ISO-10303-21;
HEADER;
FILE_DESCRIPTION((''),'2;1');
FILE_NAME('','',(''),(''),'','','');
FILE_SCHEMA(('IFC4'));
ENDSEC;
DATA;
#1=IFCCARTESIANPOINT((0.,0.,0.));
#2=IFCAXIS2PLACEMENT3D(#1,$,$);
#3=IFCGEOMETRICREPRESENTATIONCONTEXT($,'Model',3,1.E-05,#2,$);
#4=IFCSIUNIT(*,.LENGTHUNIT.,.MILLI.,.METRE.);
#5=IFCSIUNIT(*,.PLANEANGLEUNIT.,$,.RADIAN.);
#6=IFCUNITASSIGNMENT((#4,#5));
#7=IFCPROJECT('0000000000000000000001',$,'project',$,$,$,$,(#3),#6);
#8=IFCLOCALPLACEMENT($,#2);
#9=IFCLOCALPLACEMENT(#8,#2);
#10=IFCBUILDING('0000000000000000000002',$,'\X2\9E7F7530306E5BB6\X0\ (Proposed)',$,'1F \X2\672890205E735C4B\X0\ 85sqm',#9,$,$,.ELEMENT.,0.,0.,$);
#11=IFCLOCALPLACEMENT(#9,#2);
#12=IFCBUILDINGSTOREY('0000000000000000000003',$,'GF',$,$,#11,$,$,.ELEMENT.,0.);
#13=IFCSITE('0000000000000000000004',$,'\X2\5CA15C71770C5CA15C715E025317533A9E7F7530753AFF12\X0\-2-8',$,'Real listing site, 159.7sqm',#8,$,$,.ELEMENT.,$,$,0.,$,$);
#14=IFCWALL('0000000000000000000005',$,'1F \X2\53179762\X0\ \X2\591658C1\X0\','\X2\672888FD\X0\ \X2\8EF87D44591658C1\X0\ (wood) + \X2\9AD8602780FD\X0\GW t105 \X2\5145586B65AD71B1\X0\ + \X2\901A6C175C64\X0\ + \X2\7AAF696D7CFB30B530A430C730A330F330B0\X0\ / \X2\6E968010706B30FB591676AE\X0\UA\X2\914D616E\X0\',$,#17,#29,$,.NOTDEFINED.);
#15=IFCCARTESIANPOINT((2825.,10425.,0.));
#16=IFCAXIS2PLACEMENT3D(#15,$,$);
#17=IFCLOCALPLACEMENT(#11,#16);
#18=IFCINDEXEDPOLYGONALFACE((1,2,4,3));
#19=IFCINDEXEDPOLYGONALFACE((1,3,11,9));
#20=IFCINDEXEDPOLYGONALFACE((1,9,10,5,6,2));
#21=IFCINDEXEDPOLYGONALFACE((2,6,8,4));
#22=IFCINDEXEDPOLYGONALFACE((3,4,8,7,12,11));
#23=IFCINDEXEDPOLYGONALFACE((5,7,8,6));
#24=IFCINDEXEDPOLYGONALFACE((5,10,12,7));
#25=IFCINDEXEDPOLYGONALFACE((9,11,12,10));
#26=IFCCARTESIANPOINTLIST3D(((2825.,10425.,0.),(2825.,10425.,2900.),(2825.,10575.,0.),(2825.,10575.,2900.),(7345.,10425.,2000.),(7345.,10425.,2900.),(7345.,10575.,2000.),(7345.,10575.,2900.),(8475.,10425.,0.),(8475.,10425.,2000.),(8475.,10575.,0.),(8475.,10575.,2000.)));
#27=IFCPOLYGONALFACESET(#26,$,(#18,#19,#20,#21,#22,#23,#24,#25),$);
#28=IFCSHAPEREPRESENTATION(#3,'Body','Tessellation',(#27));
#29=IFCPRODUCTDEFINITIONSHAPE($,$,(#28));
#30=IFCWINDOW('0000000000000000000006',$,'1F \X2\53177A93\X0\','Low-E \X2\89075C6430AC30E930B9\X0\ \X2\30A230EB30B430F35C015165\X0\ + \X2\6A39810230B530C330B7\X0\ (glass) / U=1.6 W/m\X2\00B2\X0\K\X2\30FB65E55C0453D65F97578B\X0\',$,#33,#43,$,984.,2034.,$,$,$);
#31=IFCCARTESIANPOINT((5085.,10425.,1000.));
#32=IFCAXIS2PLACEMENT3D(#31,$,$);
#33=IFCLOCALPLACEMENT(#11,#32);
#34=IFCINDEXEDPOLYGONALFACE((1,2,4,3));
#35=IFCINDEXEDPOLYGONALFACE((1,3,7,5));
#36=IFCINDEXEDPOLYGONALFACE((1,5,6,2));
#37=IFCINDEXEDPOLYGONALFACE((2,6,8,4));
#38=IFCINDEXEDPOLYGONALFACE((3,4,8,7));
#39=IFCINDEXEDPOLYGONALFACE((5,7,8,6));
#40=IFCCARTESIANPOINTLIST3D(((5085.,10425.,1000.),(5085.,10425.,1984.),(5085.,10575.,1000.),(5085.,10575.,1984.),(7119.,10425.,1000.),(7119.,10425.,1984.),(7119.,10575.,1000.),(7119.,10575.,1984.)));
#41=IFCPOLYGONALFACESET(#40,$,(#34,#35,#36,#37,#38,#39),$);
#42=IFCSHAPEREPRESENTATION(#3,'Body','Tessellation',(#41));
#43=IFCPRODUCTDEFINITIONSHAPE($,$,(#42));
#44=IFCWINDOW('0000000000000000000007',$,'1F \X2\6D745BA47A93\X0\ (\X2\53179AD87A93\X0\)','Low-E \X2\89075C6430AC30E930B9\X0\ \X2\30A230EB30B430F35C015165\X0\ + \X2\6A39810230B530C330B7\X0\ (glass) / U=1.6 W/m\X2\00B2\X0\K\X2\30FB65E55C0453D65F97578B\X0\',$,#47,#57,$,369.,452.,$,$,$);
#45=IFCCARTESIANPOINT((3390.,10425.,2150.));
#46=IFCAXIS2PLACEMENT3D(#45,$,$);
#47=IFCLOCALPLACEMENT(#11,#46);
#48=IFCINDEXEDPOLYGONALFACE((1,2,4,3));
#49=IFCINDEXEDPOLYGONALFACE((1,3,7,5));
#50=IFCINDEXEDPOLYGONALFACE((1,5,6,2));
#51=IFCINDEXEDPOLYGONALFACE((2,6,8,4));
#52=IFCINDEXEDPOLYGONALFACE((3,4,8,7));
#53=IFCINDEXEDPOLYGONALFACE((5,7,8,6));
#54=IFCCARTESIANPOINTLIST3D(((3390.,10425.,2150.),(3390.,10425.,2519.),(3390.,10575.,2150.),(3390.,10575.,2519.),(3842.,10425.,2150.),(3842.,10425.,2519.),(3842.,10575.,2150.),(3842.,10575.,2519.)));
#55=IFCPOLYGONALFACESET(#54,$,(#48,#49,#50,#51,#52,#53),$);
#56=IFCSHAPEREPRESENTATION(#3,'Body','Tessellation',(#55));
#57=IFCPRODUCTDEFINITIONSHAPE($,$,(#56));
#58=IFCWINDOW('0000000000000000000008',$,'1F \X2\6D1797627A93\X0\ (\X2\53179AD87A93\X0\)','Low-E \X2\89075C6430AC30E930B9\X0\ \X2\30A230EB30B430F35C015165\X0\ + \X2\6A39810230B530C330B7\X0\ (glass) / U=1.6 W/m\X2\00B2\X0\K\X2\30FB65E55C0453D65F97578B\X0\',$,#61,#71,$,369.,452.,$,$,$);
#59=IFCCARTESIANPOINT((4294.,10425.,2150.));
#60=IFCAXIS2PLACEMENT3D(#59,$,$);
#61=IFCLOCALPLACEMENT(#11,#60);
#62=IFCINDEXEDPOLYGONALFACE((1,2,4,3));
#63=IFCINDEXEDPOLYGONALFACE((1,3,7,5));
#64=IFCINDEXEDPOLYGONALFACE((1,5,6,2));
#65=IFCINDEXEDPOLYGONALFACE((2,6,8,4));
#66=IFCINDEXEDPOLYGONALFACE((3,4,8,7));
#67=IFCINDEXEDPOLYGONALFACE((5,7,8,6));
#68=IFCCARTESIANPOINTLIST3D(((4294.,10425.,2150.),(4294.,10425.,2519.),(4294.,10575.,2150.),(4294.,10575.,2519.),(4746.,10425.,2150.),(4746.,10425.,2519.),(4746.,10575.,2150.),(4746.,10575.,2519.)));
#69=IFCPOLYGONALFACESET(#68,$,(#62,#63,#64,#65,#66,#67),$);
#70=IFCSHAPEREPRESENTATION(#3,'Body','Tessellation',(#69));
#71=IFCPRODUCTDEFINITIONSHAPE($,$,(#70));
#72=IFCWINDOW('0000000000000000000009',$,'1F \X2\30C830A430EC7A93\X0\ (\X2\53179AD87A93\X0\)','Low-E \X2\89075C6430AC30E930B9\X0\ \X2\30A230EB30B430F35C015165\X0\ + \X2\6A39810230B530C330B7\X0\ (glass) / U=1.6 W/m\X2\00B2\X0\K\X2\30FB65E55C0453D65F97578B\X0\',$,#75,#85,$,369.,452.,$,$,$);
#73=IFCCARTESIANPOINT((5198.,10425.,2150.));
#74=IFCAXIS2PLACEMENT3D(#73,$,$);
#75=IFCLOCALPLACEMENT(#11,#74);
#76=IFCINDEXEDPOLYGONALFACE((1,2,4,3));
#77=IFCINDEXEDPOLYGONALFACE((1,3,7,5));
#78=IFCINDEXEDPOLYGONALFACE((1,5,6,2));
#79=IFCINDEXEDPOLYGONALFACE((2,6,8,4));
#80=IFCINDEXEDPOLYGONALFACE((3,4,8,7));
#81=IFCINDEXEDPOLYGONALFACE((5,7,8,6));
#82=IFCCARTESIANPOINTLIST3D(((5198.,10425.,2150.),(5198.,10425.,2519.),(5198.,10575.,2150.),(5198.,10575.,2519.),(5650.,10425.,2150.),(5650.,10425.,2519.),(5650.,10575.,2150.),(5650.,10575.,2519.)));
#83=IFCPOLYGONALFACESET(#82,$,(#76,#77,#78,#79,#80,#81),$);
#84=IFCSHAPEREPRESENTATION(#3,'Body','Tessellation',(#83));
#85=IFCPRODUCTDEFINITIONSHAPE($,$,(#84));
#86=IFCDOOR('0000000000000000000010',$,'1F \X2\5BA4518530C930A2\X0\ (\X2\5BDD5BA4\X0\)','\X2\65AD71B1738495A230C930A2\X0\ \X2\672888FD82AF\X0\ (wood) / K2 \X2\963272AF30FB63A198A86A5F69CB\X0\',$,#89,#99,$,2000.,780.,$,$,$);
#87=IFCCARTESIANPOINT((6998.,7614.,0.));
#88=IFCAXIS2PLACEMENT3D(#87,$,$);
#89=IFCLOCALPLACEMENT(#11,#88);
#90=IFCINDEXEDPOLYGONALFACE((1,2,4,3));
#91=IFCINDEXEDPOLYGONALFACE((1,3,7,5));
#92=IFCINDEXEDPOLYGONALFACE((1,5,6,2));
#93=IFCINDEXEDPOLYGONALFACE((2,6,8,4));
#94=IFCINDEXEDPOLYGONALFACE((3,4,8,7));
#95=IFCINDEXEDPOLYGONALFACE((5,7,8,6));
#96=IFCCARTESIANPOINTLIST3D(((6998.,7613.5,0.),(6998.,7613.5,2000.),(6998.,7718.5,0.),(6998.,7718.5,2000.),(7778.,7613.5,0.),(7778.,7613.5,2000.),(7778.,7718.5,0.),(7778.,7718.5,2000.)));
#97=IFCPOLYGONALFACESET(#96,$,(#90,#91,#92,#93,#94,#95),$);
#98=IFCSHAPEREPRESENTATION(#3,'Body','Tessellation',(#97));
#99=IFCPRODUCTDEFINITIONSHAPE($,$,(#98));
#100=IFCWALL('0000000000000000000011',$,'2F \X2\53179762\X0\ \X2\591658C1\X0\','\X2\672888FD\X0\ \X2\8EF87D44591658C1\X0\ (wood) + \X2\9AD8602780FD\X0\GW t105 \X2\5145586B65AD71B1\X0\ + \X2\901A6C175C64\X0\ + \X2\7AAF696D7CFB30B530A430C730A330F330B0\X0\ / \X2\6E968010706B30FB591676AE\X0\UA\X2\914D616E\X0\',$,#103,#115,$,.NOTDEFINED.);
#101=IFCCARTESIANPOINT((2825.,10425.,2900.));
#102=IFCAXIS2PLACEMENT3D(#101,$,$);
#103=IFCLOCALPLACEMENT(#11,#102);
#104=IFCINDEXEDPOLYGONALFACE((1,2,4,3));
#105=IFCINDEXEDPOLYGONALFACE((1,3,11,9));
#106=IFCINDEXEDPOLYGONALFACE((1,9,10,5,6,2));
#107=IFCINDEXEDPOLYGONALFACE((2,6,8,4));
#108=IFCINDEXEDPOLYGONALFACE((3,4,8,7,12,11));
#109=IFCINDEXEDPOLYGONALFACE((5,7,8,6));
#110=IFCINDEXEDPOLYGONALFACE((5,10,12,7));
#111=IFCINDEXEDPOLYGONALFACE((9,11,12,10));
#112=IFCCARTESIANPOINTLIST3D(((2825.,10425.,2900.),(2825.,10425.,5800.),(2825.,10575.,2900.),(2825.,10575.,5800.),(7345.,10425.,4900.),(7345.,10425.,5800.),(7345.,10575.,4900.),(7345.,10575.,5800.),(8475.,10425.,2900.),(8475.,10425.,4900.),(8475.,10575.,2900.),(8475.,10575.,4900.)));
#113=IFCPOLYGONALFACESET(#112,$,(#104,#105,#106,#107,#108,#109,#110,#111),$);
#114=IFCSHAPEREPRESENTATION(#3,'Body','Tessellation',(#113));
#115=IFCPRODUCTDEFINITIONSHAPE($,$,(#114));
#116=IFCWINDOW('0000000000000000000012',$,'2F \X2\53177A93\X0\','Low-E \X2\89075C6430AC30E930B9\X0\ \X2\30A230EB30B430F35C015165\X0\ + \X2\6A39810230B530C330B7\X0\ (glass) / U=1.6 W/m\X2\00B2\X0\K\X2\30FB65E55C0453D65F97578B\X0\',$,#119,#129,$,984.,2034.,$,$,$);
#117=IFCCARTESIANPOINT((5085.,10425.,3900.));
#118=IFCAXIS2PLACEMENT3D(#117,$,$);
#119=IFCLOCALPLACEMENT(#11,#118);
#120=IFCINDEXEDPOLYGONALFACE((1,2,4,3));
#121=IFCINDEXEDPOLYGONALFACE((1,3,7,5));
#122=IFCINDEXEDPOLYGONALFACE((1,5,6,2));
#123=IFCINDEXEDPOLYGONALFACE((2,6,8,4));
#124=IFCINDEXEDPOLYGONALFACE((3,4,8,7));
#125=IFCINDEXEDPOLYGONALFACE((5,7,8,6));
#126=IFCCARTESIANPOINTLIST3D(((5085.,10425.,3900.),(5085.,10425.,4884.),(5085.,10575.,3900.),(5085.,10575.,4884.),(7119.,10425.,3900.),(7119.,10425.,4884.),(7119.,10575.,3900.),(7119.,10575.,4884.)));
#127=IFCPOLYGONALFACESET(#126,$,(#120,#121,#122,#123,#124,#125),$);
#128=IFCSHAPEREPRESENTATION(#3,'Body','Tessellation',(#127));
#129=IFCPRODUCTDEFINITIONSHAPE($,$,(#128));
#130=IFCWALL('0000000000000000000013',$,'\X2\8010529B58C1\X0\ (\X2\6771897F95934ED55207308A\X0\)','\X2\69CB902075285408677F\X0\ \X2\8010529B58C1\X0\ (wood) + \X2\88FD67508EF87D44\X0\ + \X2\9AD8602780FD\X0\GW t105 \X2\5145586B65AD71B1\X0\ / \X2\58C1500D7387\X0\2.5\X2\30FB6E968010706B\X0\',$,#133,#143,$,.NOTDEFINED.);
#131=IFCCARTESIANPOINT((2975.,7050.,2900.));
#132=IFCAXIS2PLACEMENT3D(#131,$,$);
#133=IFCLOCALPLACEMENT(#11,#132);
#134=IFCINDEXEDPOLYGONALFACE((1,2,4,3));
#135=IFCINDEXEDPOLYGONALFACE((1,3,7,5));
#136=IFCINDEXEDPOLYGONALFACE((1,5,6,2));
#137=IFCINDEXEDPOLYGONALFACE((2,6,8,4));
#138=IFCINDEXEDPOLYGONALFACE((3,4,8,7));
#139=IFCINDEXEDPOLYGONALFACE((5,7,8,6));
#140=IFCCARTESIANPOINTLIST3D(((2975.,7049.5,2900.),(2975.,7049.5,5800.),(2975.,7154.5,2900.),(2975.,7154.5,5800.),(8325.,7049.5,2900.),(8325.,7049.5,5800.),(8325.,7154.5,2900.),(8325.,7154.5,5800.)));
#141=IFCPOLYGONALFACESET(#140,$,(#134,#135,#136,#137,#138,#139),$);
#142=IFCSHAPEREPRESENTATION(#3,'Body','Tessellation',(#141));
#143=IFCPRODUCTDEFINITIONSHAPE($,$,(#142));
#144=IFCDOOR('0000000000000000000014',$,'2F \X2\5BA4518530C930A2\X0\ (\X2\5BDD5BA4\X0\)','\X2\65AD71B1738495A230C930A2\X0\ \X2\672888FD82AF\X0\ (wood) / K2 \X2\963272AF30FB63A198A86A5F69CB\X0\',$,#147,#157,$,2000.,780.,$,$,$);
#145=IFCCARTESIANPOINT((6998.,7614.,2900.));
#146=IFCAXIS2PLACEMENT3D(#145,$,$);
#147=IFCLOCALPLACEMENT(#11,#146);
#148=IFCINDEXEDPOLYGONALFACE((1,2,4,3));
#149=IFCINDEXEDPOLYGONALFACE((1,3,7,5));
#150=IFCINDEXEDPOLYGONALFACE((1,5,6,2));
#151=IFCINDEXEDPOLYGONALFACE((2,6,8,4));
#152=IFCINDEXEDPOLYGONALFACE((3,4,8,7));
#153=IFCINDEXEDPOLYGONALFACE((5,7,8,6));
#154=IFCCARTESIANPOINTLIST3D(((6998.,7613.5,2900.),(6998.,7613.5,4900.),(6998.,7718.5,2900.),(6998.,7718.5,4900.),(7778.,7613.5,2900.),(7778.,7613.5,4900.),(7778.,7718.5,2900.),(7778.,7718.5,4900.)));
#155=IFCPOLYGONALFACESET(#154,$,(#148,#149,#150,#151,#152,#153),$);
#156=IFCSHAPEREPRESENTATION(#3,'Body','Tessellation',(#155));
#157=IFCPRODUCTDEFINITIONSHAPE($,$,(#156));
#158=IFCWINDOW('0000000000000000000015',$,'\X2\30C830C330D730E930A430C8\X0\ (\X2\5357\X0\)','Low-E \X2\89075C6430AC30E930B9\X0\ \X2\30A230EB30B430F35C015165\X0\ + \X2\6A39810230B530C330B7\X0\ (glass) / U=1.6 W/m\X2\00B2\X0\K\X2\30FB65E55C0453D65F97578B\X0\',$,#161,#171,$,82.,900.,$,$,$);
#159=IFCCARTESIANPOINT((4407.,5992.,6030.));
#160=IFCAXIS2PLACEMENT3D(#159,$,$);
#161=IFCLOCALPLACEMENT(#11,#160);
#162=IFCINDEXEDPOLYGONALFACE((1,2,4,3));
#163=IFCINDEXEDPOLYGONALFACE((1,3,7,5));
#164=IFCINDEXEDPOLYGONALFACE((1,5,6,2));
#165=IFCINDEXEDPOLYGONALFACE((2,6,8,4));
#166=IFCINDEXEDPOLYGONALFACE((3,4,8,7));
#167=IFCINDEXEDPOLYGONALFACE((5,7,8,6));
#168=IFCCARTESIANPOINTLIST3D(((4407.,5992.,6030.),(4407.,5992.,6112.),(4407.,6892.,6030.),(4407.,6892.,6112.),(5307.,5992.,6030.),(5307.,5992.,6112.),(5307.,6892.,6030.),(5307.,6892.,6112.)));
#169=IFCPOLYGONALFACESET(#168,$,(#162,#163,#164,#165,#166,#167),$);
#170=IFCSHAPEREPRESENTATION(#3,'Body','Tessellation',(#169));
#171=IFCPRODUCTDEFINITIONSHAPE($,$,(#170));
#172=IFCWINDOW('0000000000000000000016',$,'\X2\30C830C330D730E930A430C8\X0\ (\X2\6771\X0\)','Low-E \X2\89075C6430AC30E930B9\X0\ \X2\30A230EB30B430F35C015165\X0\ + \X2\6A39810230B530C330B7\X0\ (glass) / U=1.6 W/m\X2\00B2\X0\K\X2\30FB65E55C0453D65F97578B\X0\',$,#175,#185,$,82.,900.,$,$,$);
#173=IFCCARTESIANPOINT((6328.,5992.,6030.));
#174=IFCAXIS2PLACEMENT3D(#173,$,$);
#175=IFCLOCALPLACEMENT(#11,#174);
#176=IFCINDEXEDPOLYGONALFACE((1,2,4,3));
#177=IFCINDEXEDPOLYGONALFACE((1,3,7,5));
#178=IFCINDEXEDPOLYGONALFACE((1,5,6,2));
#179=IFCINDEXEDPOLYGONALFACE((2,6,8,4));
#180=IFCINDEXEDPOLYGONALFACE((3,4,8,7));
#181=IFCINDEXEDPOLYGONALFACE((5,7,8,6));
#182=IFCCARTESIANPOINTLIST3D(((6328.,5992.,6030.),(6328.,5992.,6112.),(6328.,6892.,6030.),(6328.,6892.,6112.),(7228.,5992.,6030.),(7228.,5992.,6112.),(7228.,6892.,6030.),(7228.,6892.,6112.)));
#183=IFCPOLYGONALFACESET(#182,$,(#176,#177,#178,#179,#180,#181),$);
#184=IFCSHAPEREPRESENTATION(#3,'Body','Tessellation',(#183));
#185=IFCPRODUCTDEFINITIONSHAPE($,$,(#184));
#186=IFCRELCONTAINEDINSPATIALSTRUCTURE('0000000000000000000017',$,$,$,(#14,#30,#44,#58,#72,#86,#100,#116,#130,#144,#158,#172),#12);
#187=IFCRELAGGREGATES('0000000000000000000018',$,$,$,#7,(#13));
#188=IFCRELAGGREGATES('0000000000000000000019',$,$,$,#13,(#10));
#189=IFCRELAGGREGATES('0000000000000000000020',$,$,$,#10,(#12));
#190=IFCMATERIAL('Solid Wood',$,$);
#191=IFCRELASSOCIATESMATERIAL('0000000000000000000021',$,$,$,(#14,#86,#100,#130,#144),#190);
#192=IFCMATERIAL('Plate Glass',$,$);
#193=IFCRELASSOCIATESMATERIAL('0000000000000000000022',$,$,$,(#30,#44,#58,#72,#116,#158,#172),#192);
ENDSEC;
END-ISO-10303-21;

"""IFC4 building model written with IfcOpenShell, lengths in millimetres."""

from ifc_helpers import new_model, si_unit, frame, frame_2d, origin, place, context, project, spatial, rectangle, extrude, material, element, fill, save


model = new_model("IFC4")

# Units and contexts
model_context = context("Model", 3, precision=1e-05, world=origin())
ifc_project = project(units=[si_unit("LENGTHUNIT", "METRE", prefix="MILLI"), si_unit("PLANEANGLEUNIT", "RADIAN")], contexts=[model_context])

# Site, building, storey
site_placement = place(None, origin())
site = spatial("IfcSite", under=ifc_project, at=site_placement, Name="岡山県岡山市北区鹿田町２-2-8", ObjectType="Real listing site, 159.7sqm", CompositionType="ELEMENT", RefElevation=0.0)
building_placement = place(site_placement, origin())
building = spatial("IfcBuilding", under=site, at=building_placement, Name="鹿田の家 (Proposed)", ObjectType="1F 木造平屋 85sqm", CompositionType="ELEMENT", ElevationOfRefHeight=0.0, ElevationOfTerrain=0.0)
storey_placement = place(building_placement, origin())
storey = spatial("IfcBuildingStorey", under=building, at=storey_placement, Name="GF", CompositionType="ELEMENT", Elevation=0.0)

# Wall, openings, windows
ifc_material_1 = material(Name="Solid Wood")
wall_1_placement = place(storey_placement, frame((2825.0, 10425.0, 0.0)))
wall_1 = element("IfcWall", 1, at=wall_1_placement, inside=storey, material=ifc_material_1, Name="1F 北面 外壁", Description="木製 軸組外壁 (wood) + 高性能GW t105 充填断熱 + 通気層 + 窯業系サイディング / 準耐火・外皮UA配慮", PredefinedType="NOTDEFINED", context=model_context, shape_type="SweptSolid", body=[
    extrude(rectangle(XDim=5650.0, YDim=150.0, at=frame_2d((2825.0, 75.0))), frame((2825.0, 10425.0, 0.0)), (0.0, 0.0, 1.0), 2900.0),
])
opening_1_placement = place(storey_placement, frame((5085.0, 10425.0, 1000.0)))
opening_1 = element("IfcOpeningElement", 2, at=opening_1_placement, cuts=wall_1, PredefinedType="NOTDEFINED", context=model_context, shape_type="SweptSolid", body=[
    extrude(rectangle(XDim=2034.0, YDim=150.0, at=frame_2d((1017.0, 75.0))), frame((5085.0, 10425.0, 1000.0)), (0.0, 0.0, 1.0), 984.0),
])
opening_2_placement = place(storey_placement, frame((3390.0, 10425.0, 2150.0)))
opening_2 = element("IfcOpeningElement", 3, at=opening_2_placement, cuts=wall_1, PredefinedType="NOTDEFINED", context=model_context, shape_type="SweptSolid", body=[
    extrude(rectangle(XDim=452.0, YDim=150.0, at=frame_2d((226.0, 75.0))), frame((3390.0, 10425.0, 2150.0)), (0.0, 0.0, 1.0), 369.0),
])
opening_3_placement = place(storey_placement, frame((4294.0, 10425.0, 2150.0)))
opening_3 = element("IfcOpeningElement", 4, at=opening_3_placement, cuts=wall_1, PredefinedType="NOTDEFINED", context=model_context, shape_type="SweptSolid", body=[
    extrude(rectangle(XDim=452.0, YDim=150.0, at=frame_2d((226.0, 75.0))), frame((4294.0, 10425.0, 2150.0)), (0.0, 0.0, 1.0), 369.0),
])
opening_4_placement = place(storey_placement, frame((5198.0, 10425.0, 2150.0)))
opening_4 = element("IfcOpeningElement", 5, at=opening_4_placement, cuts=wall_1, PredefinedType="NOTDEFINED", context=model_context, shape_type="SweptSolid", body=[
    extrude(rectangle(XDim=452.0, YDim=150.0, at=frame_2d((226.0, 75.0))), frame((5198.0, 10425.0, 2150.0)), (0.0, 0.0, 1.0), 369.0),
])
ifc_material_2 = material(Name="Plate Glass")
window_1_placement = place(storey_placement, frame((5085.0, 10425.0, 1000.0)))
window_1 = element("IfcWindow", 6, at=window_1_placement, inside=storey, material=ifc_material_2, Name="1F 北窓", Description="Low-E 複層ガラス アルゴン封入 + 樹脂サッシ (glass) / U=1.6 W/m²K・日射取得型", OverallHeight=984.0, OverallWidth=2034.0, context=model_context, shape_type="SweptSolid", body=[
    extrude(rectangle(XDim=2034.0, YDim=150.0, at=frame_2d((1017.0, 75.0))), frame((5085.0, 10425.0, 1000.0)), (0.0, 0.0, 1.0), 984.0),
])
fill(opening_1, window_1)
window_2_placement = place(storey_placement, frame((3390.0, 10425.0, 2150.0)))
window_2 = element("IfcWindow", 7, at=window_2_placement, inside=storey, material=ifc_material_2, Name="1F 浴室窓 (北高窓)", Description="Low-E 複層ガラス アルゴン封入 + 樹脂サッシ (glass) / U=1.6 W/m²K・日射取得型", OverallHeight=369.0, OverallWidth=452.0, context=model_context, shape_type="SweptSolid", body=[
    extrude(rectangle(XDim=452.0, YDim=150.0, at=frame_2d((226.0, 75.0))), frame((3390.0, 10425.0, 2150.0)), (0.0, 0.0, 1.0), 369.0),
])
fill(opening_2, window_2)
window_3_placement = place(storey_placement, frame((4294.0, 10425.0, 2150.0)))
window_3 = element("IfcWindow", 8, at=window_3_placement, inside=storey, material=ifc_material_2, Name="1F 洗面窓 (北高窓)", Description="Low-E 複層ガラス アルゴン封入 + 樹脂サッシ (glass) / U=1.6 W/m²K・日射取得型", OverallHeight=369.0, OverallWidth=452.0, context=model_context, shape_type="SweptSolid", body=[
    extrude(rectangle(XDim=452.0, YDim=150.0, at=frame_2d((226.0, 75.0))), frame((4294.0, 10425.0, 2150.0)), (0.0, 0.0, 1.0), 369.0),
])
fill(opening_3, window_3)
window_4_placement = place(storey_placement, frame((5198.0, 10425.0, 2150.0)))
window_4 = element("IfcWindow", 9, at=window_4_placement, inside=storey, material=ifc_material_2, Name="1F トイレ窓 (北高窓)", Description="Low-E 複層ガラス アルゴン封入 + 樹脂サッシ (glass) / U=1.6 W/m²K・日射取得型", OverallHeight=369.0, OverallWidth=452.0, context=model_context, shape_type="SweptSolid", body=[
    extrude(rectangle(XDim=452.0, YDim=150.0, at=frame_2d((226.0, 75.0))), frame((5198.0, 10425.0, 2150.0)), (0.0, 0.0, 1.0), 369.0),
])
fill(opening_4, window_4)

# Door
door_1_placement = place(storey_placement, frame((6998.0, 7614.0, 0.0)))
element("IfcDoor", 10, at=door_1_placement, inside=storey, material=ifc_material_1, Name="1F 室内ドア (寝室)", Description="断熱玄関ドア 木製芯 (wood) / K2 防犯・採風機構", OverallHeight=2000.0, OverallWidth=780.0, context=model_context, shape_type="SweptSolid", body=[
    extrude(rectangle(XDim=780.0, YDim=105.0, at=frame_2d((390.0, 52.0))), frame((6998.0, 7614.0, 0.0)), (0.0, 0.0, 1.0), 2000.0),
])

# Wall, opening, window
wall_2_placement = place(storey_placement, frame((2825.0, 10425.0, 2900.0)))
wall_2 = element("IfcWall", 11, at=wall_2_placement, inside=storey, material=ifc_material_1, Name="2F 北面 外壁", Description="木製 軸組外壁 (wood) + 高性能GW t105 充填断熱 + 通気層 + 窯業系サイディング / 準耐火・外皮UA配慮", PredefinedType="NOTDEFINED", context=model_context, shape_type="SweptSolid", body=[
    extrude(rectangle(XDim=5650.0, YDim=150.0, at=frame_2d((2825.0, 75.0))), frame((2825.0, 10425.0, 2900.0)), (0.0, 0.0, 1.0), 2900.0),
])
opening_5_placement = place(storey_placement, frame((5085.0, 10425.0, 3900.0)))
opening_5 = element("IfcOpeningElement", 12, at=opening_5_placement, cuts=wall_2, PredefinedType="NOTDEFINED", context=model_context, shape_type="SweptSolid", body=[
    extrude(rectangle(XDim=2034.0, YDim=150.0, at=frame_2d((1017.0, 75.0))), frame((5085.0, 10425.0, 3900.0)), (0.0, 0.0, 1.0), 984.0),
])
window_5_placement = place(storey_placement, frame((5085.0, 10425.0, 3900.0)))
window_5 = element("IfcWindow", 13, at=window_5_placement, inside=storey, material=ifc_material_2, Name="2F 北窓", Description="Low-E 複層ガラス アルゴン封入 + 樹脂サッシ (glass) / U=1.6 W/m²K・日射取得型", OverallHeight=984.0, OverallWidth=2034.0, context=model_context, shape_type="SweptSolid", body=[
    extrude(rectangle(XDim=2034.0, YDim=150.0, at=frame_2d((1017.0, 75.0))), frame((5085.0, 10425.0, 3900.0)), (0.0, 0.0, 1.0), 984.0),
])
fill(opening_5, window_5)

# Wall
wall_3_placement = place(storey_placement, frame((2975.0, 7050.0, 2900.0)))
element("IfcWall", 14, at=wall_3_placement, inside=storey, material=ifc_material_1, Name="耐力壁 (東西間仕切り)", Description="構造用合板 耐力壁 (wood) + 製材軸組 + 高性能GW t105 充填断熱 / 壁倍率2.5・準耐火", PredefinedType="NOTDEFINED", context=model_context, shape_type="SweptSolid", body=[
    extrude(rectangle(XDim=5350.0, YDim=105.0, at=frame_2d((2675.0, 52.0))), frame((2975.0, 7050.0, 2900.0)), (0.0, 0.0, 1.0), 2900.0),
])

# Door
door_2_placement = place(storey_placement, frame((6998.0, 7614.0, 2900.0)))
element("IfcDoor", 15, at=door_2_placement, inside=storey, material=ifc_material_1, Name="2F 室内ドア (寝室)", Description="断熱玄関ドア 木製芯 (wood) / K2 防犯・採風機構", OverallHeight=2000.0, OverallWidth=780.0, context=model_context, shape_type="SweptSolid", body=[
    extrude(rectangle(XDim=780.0, YDim=105.0, at=frame_2d((390.0, 52.0))), frame((6998.0, 7614.0, 2900.0)), (0.0, 0.0, 1.0), 2000.0),
])

# Windows
window_6_placement = place(storey_placement, frame((4407.0, 5992.0, 6030.0)))
element("IfcWindow", 16, at=window_6_placement, inside=storey, material=ifc_material_2, Name="トップライト (南)", Description="Low-E 複層ガラス アルゴン封入 + 樹脂サッシ (glass) / U=1.6 W/m²K・日射取得型", OverallHeight=82.0, OverallWidth=900.0, context=model_context, shape_type="SweptSolid", body=[
    extrude(rectangle(XDim=900.0, YDim=900.0, at=frame_2d((450.0, 450.0))), frame((4407.0, 5992.0, 6030.0)), (0.0, 0.0, 1.0), 82.0),
])
window_7_placement = place(storey_placement, frame((6328.0, 5992.0, 6030.0)))
element("IfcWindow", 17, at=window_7_placement, inside=storey, material=ifc_material_2, Name="トップライト (東)", Description="Low-E 複層ガラス アルゴン封入 + 樹脂サッシ (glass) / U=1.6 W/m²K・日射取得型", OverallHeight=82.0, OverallWidth=900.0, context=model_context, shape_type="SweptSolid", body=[
    extrude(rectangle(XDim=900.0, YDim=900.0, at=frame_2d((450.0, 450.0))), frame((6328.0, 5992.0, 6030.0)), (0.0, 0.0, 1.0), 82.0),
])

save(model, "model.ifc")
